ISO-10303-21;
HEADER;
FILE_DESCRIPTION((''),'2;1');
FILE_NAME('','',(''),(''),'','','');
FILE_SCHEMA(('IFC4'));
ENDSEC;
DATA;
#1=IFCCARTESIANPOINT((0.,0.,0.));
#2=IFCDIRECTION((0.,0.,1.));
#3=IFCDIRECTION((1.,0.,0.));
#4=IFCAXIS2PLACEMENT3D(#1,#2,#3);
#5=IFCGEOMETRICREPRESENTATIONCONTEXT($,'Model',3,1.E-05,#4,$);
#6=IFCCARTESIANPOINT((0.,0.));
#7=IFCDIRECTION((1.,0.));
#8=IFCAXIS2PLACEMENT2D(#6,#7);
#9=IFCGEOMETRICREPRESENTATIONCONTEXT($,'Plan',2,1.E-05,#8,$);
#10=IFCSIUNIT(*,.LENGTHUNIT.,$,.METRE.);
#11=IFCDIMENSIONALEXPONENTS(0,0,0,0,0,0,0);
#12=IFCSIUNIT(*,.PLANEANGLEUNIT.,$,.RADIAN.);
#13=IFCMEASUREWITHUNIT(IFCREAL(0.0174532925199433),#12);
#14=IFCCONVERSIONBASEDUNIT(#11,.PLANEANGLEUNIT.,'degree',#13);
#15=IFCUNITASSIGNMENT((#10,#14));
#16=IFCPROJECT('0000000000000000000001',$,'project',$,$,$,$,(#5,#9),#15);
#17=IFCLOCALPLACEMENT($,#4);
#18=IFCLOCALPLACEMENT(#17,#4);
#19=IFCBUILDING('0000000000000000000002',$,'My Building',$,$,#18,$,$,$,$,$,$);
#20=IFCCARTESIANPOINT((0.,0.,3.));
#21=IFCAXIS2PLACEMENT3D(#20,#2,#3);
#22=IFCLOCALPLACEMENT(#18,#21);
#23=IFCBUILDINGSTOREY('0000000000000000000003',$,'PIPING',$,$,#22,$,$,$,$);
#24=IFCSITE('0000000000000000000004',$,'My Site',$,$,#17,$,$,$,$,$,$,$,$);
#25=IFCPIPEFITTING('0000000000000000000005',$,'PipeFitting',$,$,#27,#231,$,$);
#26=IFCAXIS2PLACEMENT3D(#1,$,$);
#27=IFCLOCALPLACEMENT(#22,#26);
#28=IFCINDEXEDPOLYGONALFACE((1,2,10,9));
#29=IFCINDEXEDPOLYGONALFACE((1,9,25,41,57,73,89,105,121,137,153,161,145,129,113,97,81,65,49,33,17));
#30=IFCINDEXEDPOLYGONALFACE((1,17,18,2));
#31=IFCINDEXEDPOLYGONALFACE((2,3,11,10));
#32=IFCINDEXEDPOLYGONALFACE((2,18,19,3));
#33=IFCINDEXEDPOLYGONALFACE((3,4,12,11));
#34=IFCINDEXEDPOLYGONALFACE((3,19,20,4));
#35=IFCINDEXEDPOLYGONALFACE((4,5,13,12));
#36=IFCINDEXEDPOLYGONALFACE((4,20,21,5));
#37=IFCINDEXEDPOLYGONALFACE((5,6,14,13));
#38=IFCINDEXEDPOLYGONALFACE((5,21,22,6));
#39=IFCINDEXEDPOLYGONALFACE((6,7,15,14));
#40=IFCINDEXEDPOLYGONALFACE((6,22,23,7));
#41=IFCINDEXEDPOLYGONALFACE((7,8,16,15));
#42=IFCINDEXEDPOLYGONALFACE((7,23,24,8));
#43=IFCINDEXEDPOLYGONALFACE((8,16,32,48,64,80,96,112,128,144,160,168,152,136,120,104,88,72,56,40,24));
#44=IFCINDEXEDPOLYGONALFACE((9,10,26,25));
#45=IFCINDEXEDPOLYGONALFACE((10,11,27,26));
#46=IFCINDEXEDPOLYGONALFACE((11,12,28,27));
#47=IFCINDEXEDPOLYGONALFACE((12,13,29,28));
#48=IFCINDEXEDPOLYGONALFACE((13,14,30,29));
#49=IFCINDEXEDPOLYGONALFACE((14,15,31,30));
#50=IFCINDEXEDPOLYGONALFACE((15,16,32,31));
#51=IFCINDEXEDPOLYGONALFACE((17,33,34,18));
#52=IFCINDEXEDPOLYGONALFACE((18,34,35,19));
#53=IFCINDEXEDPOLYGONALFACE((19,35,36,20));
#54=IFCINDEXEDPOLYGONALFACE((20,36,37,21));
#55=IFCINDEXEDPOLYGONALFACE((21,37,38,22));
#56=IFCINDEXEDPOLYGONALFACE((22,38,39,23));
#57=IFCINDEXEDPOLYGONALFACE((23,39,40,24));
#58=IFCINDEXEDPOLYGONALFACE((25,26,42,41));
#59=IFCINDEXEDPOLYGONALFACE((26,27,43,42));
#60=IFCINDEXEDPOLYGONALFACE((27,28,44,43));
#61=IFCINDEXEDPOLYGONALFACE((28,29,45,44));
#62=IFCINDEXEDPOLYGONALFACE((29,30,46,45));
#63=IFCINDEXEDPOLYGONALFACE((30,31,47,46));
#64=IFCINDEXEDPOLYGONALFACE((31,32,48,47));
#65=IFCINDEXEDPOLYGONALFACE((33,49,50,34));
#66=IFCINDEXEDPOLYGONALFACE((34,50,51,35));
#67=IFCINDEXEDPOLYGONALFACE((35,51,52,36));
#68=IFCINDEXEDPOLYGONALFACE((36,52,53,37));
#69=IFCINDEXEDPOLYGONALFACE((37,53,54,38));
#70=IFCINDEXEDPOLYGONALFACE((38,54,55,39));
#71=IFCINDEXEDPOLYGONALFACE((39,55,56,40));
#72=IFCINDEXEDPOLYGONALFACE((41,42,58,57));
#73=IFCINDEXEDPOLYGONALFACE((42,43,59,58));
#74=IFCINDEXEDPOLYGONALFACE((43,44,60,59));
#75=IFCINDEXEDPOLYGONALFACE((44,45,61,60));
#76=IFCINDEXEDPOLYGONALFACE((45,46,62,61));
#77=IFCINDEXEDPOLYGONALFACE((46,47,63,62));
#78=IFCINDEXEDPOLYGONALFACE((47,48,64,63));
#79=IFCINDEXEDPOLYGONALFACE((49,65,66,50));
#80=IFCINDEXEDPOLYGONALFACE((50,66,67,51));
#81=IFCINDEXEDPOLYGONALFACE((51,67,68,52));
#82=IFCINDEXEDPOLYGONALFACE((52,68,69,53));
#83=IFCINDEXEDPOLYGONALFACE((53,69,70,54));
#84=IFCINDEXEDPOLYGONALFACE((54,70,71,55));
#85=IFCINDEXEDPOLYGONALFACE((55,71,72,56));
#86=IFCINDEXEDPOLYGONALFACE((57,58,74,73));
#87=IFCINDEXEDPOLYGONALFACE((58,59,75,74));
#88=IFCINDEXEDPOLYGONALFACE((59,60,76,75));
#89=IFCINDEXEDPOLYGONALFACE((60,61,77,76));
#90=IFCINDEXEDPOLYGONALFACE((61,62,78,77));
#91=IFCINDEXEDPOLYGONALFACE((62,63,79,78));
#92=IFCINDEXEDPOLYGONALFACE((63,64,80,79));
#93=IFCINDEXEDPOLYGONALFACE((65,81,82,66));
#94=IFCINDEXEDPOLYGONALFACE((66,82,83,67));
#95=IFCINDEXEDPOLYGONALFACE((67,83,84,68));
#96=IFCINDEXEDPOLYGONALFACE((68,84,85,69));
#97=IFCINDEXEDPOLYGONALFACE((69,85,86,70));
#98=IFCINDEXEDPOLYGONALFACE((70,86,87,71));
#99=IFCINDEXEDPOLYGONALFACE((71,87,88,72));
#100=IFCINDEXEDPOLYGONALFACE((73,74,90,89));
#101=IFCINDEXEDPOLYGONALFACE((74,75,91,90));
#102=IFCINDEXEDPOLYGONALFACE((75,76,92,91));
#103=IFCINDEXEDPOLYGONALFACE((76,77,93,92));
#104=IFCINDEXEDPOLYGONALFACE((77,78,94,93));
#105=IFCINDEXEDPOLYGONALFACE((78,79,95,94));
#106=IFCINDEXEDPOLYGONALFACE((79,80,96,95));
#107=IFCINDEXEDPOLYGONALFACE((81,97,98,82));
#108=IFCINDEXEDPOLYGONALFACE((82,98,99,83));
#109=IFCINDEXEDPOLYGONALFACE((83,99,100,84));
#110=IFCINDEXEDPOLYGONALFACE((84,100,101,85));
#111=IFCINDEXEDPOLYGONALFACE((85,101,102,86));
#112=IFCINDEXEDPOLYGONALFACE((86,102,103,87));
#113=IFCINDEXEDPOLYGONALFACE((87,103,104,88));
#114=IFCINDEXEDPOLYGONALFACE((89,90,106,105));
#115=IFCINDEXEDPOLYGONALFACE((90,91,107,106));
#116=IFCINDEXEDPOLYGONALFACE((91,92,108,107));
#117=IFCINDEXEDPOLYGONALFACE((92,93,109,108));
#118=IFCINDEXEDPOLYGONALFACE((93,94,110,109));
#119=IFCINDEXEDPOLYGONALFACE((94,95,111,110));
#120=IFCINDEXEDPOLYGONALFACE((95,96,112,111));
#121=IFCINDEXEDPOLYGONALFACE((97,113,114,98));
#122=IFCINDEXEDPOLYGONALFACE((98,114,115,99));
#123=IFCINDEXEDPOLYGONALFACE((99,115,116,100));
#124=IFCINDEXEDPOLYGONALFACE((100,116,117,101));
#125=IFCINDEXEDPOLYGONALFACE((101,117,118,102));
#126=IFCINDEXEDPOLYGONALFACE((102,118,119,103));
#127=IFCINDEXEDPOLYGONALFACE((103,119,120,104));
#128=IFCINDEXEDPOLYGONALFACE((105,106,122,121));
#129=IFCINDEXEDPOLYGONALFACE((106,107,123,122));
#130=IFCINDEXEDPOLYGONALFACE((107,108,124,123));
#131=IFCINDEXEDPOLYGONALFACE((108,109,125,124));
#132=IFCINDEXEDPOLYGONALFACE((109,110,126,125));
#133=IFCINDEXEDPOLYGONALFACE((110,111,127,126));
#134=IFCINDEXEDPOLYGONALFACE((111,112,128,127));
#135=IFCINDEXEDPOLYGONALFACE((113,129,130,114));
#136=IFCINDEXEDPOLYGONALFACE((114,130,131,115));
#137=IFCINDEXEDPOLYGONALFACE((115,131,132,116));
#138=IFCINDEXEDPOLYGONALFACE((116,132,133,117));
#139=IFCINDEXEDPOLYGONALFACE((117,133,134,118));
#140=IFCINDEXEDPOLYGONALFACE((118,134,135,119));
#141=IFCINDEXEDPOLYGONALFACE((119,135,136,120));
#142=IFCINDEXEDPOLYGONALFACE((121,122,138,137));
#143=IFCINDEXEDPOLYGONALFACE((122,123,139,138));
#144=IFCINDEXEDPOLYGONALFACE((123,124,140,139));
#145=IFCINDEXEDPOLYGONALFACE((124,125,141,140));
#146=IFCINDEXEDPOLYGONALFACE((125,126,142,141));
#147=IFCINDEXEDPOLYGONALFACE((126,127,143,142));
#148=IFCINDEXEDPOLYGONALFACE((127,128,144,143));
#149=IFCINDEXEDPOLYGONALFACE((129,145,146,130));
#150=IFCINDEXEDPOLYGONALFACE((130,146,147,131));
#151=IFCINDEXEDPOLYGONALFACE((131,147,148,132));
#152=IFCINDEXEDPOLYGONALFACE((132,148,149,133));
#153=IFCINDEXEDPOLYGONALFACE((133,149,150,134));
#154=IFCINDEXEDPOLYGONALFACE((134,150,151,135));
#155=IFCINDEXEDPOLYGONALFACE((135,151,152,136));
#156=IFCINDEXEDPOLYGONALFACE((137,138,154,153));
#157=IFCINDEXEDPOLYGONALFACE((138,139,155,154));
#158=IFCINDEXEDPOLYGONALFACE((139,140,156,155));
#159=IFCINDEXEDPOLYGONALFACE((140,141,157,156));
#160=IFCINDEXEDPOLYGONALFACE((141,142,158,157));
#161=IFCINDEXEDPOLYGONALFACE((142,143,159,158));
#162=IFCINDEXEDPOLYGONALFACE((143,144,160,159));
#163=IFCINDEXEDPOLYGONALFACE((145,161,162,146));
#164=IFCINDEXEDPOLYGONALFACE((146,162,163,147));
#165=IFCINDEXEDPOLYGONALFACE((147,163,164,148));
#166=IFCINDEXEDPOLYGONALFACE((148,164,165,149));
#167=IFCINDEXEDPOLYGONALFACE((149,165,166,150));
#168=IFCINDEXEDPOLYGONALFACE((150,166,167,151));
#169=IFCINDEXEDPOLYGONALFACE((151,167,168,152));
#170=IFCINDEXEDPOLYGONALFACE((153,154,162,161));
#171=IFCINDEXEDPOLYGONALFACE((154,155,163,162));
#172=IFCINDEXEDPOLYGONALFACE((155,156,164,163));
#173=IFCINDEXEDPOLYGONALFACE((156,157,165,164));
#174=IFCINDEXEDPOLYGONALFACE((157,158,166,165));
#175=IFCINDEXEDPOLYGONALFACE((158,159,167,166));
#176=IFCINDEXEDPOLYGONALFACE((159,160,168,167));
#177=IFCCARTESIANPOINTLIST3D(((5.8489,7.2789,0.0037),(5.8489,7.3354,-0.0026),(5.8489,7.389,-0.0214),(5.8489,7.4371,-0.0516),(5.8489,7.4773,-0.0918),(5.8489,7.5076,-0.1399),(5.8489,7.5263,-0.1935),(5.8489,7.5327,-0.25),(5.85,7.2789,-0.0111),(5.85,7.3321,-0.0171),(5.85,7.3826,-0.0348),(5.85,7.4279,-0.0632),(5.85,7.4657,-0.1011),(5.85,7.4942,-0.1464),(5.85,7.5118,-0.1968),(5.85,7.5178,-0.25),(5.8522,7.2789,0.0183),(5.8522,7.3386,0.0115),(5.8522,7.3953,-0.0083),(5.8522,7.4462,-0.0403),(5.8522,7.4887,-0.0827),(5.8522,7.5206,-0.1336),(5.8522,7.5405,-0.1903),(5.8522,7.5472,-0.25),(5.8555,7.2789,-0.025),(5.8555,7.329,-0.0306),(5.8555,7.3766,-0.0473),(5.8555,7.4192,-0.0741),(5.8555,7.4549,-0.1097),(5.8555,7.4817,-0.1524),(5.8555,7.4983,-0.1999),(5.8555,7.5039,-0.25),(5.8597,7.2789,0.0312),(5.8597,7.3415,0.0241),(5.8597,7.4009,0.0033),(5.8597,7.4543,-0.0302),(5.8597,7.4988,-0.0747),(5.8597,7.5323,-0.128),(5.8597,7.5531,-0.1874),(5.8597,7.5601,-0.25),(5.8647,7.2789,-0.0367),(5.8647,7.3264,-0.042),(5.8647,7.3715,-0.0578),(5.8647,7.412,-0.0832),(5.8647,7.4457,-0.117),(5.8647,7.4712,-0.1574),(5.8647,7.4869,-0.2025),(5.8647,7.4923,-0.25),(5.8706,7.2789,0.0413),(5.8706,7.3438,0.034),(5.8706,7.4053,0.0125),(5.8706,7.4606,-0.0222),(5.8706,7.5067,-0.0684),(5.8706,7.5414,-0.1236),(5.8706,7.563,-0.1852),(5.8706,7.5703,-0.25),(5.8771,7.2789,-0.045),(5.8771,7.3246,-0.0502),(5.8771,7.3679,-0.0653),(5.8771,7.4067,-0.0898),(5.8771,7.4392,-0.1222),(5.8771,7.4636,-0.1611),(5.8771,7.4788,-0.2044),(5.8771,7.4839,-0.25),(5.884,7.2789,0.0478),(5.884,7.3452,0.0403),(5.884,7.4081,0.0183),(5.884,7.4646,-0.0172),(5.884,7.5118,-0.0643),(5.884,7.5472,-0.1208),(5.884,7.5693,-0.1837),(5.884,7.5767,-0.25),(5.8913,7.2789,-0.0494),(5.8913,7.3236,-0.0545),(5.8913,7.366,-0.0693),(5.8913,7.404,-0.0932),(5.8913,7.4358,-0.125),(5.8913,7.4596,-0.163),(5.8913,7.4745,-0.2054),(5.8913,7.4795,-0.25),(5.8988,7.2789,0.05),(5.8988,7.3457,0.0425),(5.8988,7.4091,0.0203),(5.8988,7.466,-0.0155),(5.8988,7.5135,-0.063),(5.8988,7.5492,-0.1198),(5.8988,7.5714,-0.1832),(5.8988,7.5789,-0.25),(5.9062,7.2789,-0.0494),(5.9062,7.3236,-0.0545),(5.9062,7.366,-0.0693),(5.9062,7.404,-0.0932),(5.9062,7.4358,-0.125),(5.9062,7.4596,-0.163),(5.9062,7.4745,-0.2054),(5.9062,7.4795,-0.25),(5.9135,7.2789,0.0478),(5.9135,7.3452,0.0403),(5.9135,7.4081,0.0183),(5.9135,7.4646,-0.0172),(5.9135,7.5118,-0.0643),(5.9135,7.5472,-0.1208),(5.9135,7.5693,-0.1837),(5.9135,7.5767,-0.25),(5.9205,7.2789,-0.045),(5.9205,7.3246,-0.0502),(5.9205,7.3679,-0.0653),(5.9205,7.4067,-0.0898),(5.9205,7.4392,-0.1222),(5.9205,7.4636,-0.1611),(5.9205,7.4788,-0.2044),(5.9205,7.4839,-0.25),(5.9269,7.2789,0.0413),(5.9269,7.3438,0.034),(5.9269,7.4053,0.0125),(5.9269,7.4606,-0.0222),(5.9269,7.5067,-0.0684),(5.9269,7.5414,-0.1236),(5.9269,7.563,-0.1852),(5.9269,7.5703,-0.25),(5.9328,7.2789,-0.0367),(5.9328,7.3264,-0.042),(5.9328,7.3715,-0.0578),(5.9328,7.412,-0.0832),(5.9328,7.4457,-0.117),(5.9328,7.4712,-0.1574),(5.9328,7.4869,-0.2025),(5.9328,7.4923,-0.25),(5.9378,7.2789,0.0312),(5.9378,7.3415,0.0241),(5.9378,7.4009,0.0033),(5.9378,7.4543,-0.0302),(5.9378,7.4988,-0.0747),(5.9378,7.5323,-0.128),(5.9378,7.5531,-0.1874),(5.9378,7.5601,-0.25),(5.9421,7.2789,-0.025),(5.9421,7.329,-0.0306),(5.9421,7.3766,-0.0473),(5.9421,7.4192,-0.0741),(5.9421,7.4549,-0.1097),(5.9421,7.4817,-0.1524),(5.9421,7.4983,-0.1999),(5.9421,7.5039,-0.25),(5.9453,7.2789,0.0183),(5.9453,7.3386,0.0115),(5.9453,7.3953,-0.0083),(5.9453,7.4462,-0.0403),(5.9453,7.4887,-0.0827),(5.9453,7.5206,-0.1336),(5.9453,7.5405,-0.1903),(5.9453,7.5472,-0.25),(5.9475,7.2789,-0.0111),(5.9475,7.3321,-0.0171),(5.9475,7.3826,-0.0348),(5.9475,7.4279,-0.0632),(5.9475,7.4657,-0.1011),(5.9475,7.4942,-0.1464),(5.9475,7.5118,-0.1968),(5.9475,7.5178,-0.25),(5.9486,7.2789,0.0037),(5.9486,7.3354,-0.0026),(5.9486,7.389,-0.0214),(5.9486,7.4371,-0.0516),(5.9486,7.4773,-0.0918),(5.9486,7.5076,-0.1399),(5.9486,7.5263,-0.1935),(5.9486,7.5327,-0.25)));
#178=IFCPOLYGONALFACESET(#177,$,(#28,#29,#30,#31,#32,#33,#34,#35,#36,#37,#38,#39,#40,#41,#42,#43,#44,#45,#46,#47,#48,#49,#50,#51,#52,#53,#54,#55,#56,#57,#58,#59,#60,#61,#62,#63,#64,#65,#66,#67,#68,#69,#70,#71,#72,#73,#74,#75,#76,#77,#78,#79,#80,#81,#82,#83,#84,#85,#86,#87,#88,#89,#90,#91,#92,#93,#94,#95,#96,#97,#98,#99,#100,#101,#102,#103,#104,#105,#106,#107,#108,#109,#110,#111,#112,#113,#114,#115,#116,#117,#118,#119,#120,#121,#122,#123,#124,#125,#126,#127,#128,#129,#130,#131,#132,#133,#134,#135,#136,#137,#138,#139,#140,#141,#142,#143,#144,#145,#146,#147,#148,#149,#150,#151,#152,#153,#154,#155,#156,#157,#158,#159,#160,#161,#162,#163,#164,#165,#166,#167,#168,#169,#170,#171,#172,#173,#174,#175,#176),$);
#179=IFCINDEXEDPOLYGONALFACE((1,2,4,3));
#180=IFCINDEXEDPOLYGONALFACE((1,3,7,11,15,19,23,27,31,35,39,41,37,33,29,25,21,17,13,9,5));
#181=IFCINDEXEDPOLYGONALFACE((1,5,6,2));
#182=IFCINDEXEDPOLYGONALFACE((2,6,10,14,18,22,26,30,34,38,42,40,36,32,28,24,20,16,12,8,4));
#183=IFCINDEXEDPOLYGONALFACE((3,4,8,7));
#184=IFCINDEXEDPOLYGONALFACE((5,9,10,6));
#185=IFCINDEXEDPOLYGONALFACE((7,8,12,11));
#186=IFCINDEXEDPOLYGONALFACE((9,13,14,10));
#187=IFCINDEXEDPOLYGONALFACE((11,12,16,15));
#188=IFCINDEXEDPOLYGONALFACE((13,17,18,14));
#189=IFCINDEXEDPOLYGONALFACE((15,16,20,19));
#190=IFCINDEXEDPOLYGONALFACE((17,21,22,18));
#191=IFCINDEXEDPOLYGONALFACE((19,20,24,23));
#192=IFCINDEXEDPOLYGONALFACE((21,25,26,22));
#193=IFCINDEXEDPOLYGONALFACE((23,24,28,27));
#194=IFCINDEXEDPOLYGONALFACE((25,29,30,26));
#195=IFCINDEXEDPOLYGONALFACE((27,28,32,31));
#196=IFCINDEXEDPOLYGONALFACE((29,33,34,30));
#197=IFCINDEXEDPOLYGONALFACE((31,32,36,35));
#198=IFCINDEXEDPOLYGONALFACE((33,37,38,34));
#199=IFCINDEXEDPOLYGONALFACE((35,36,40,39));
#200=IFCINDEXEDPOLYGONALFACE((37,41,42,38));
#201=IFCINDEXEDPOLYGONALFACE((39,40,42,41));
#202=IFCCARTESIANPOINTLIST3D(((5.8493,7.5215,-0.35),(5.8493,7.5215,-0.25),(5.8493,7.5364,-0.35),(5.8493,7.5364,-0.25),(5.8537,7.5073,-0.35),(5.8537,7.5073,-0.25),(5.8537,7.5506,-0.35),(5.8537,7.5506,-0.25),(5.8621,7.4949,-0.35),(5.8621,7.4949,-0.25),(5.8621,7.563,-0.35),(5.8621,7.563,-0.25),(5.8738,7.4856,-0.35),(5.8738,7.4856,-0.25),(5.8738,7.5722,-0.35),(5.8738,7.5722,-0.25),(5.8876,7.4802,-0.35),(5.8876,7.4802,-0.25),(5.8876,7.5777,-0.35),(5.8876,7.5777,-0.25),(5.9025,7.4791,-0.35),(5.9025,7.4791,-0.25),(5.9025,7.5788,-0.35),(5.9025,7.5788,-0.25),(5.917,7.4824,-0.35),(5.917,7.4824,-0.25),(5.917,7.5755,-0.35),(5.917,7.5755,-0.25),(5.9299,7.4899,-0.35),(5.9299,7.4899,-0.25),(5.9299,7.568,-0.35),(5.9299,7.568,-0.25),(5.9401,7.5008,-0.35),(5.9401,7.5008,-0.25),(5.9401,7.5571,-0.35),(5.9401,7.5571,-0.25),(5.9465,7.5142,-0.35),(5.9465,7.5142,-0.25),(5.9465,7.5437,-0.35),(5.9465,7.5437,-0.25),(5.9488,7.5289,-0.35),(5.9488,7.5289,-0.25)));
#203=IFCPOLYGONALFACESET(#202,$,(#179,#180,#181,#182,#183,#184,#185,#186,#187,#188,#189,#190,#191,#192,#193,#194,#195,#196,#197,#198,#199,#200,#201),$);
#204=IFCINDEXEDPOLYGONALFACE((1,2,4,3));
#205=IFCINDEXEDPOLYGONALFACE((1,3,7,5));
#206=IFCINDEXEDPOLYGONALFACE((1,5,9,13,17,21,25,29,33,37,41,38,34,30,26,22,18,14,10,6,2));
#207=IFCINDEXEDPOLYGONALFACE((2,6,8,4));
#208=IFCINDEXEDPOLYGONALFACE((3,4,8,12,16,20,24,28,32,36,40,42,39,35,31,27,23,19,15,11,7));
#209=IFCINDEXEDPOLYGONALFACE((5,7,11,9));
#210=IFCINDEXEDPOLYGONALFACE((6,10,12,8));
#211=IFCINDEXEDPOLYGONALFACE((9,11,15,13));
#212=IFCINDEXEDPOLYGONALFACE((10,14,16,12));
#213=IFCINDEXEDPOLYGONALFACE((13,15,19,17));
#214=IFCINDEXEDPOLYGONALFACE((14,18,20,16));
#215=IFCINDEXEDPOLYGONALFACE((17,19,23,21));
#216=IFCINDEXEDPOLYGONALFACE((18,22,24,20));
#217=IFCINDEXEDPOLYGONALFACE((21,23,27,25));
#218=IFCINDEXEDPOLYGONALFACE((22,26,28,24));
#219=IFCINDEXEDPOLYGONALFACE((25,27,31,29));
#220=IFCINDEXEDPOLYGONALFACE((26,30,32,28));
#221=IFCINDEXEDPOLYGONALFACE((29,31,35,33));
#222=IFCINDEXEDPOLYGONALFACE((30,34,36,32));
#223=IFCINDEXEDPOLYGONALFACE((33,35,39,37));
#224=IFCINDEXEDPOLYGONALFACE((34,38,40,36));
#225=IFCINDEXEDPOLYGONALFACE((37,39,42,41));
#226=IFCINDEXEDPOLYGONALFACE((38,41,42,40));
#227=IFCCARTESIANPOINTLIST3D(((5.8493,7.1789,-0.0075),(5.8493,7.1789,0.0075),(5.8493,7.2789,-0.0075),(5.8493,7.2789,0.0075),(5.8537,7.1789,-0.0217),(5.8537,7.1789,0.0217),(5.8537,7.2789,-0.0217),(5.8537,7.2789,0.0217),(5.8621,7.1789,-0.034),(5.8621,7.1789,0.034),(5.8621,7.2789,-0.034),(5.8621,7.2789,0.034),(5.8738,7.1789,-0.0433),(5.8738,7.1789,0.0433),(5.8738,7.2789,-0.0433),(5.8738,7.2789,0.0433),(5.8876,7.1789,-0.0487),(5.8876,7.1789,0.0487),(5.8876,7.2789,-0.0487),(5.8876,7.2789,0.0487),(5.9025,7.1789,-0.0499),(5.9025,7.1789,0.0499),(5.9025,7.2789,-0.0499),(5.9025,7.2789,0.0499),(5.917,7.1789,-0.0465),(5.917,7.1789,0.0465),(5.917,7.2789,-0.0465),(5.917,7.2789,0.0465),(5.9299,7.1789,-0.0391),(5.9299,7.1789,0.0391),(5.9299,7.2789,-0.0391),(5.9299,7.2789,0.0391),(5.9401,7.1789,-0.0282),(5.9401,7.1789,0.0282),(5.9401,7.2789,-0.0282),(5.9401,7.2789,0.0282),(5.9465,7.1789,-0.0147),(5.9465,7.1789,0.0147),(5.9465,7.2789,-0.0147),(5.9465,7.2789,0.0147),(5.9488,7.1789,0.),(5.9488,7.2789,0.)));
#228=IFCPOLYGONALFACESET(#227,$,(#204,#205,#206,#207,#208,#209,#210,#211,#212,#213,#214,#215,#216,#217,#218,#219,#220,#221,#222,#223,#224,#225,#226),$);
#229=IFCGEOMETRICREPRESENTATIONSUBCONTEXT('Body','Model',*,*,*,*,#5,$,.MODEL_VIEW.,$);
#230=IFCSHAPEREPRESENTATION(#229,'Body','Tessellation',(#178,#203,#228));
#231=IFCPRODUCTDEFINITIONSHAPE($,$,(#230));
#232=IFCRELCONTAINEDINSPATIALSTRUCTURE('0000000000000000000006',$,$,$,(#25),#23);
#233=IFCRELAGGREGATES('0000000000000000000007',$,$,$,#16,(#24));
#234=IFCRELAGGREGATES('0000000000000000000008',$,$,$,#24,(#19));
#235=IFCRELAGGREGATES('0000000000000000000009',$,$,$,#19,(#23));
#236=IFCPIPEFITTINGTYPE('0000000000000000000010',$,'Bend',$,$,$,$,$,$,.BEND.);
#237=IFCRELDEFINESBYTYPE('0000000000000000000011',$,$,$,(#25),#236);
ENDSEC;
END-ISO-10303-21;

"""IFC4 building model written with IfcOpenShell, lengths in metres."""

from ifc_helpers import new_model, entity, si_unit, converted_unit, frame, origin_with_axes, origin_2d_with_axis, place, context, subcontext, project, spatial, circle, extrude, source, transform, mapped, type_object, type_shapes, element, save


model = new_model("IFC4")

# Units and contexts
model_context = context("Model", 3, precision=1e-05, world=origin_with_axes())
plan_context = context("Plan", 2, precision=1e-05, world=origin_2d_with_axis())
body_context = subcontext(model_context, "Body", "Model", "MODEL_VIEW")
ifc_project = project(units=[si_unit("LENGTHUNIT", "METRE"), converted_unit("PLANEANGLEUNIT", "degree", entity("IfcReal", 0.0174532925199433), si_unit("PLANEANGLEUNIT", "RADIAN"), dimensions=[0, 0, 0, 0, 0, 0, 0])], contexts=[model_context, plan_context])

# Site, building, storey
site_placement = place(None, origin_with_axes())
site = spatial("IfcSite", under=ifc_project, at=site_placement, Name="My Site")
building_placement = place(site_placement, origin_with_axes())
building = spatial("IfcBuilding", under=site, at=building_placement, Name="My Building")
storey_placement = place(building_placement, frame((0.0, 0.0, 3.0), z_axis=(0.0, 0.0, 1.0), x_axis=(1.0, 0.0, 0.0)))
storey = spatial("IfcBuildingStorey", under=building, at=storey_placement, Name="PIPING")

# Pipe fitting
pipe_fitting_type_1 = type_object("IfcPipeFittingType", Name="Bend", PredefinedType="BEND")
shared_shape = source(origin_with_axes(), body_context, "Body", "SolidModel", [
    entity("IfcSweptDiskSolid", entity("IfcIndexedPolyCurve", entity("IfcCartesianPointList3D", [[0.0, 0.0, -0.1], [0.0, 0.0732, -0.2768], [0.0, 0.25, -0.35]]), [entity("IfcArcIndex", [1, 2, 3])]), 0.05),
    extrude(circle(Radius=0.05), origin_with_axes(), (0.0, 0.0, -1.0), 0.1),
    extrude(circle(Radius=0.05), frame((0.0, 0.25, -0.35), z_axis=(0.0, 1.0, 0.0), x_axis=(1.0, 0.0, 0.0)), (0.0, 0.0, 1.0), 0.1),
])
type_shapes(pipe_fitting_type_1, [shared_shape])
for number, where, z_axis, x_axis, name in (
    (1, (5.8988, 7.5289, -0.35), (0.0, 0.0, -1.0), (1.0, 0.0, 0.0), "PipeFitting"),
):
    element("IfcPipeFitting", number, at=place(storey_placement, frame(where, z_axis=z_axis, x_axis=x_axis)), inside=storey, type_object=pipe_fitting_type_1, Name=name, context=body_context, shape_type="MappedRepresentation", body=[
        mapped(shared_shape, transform((0.0, 0.0, 0.0), x_axis=(1.0, 0.0, 0.0), y_axis=(0.0, 1.0, 0.0), z_axis=(0.0, 0.0, 1.0), scale=1.0)),
    ])

save(model, "model.ifc")
